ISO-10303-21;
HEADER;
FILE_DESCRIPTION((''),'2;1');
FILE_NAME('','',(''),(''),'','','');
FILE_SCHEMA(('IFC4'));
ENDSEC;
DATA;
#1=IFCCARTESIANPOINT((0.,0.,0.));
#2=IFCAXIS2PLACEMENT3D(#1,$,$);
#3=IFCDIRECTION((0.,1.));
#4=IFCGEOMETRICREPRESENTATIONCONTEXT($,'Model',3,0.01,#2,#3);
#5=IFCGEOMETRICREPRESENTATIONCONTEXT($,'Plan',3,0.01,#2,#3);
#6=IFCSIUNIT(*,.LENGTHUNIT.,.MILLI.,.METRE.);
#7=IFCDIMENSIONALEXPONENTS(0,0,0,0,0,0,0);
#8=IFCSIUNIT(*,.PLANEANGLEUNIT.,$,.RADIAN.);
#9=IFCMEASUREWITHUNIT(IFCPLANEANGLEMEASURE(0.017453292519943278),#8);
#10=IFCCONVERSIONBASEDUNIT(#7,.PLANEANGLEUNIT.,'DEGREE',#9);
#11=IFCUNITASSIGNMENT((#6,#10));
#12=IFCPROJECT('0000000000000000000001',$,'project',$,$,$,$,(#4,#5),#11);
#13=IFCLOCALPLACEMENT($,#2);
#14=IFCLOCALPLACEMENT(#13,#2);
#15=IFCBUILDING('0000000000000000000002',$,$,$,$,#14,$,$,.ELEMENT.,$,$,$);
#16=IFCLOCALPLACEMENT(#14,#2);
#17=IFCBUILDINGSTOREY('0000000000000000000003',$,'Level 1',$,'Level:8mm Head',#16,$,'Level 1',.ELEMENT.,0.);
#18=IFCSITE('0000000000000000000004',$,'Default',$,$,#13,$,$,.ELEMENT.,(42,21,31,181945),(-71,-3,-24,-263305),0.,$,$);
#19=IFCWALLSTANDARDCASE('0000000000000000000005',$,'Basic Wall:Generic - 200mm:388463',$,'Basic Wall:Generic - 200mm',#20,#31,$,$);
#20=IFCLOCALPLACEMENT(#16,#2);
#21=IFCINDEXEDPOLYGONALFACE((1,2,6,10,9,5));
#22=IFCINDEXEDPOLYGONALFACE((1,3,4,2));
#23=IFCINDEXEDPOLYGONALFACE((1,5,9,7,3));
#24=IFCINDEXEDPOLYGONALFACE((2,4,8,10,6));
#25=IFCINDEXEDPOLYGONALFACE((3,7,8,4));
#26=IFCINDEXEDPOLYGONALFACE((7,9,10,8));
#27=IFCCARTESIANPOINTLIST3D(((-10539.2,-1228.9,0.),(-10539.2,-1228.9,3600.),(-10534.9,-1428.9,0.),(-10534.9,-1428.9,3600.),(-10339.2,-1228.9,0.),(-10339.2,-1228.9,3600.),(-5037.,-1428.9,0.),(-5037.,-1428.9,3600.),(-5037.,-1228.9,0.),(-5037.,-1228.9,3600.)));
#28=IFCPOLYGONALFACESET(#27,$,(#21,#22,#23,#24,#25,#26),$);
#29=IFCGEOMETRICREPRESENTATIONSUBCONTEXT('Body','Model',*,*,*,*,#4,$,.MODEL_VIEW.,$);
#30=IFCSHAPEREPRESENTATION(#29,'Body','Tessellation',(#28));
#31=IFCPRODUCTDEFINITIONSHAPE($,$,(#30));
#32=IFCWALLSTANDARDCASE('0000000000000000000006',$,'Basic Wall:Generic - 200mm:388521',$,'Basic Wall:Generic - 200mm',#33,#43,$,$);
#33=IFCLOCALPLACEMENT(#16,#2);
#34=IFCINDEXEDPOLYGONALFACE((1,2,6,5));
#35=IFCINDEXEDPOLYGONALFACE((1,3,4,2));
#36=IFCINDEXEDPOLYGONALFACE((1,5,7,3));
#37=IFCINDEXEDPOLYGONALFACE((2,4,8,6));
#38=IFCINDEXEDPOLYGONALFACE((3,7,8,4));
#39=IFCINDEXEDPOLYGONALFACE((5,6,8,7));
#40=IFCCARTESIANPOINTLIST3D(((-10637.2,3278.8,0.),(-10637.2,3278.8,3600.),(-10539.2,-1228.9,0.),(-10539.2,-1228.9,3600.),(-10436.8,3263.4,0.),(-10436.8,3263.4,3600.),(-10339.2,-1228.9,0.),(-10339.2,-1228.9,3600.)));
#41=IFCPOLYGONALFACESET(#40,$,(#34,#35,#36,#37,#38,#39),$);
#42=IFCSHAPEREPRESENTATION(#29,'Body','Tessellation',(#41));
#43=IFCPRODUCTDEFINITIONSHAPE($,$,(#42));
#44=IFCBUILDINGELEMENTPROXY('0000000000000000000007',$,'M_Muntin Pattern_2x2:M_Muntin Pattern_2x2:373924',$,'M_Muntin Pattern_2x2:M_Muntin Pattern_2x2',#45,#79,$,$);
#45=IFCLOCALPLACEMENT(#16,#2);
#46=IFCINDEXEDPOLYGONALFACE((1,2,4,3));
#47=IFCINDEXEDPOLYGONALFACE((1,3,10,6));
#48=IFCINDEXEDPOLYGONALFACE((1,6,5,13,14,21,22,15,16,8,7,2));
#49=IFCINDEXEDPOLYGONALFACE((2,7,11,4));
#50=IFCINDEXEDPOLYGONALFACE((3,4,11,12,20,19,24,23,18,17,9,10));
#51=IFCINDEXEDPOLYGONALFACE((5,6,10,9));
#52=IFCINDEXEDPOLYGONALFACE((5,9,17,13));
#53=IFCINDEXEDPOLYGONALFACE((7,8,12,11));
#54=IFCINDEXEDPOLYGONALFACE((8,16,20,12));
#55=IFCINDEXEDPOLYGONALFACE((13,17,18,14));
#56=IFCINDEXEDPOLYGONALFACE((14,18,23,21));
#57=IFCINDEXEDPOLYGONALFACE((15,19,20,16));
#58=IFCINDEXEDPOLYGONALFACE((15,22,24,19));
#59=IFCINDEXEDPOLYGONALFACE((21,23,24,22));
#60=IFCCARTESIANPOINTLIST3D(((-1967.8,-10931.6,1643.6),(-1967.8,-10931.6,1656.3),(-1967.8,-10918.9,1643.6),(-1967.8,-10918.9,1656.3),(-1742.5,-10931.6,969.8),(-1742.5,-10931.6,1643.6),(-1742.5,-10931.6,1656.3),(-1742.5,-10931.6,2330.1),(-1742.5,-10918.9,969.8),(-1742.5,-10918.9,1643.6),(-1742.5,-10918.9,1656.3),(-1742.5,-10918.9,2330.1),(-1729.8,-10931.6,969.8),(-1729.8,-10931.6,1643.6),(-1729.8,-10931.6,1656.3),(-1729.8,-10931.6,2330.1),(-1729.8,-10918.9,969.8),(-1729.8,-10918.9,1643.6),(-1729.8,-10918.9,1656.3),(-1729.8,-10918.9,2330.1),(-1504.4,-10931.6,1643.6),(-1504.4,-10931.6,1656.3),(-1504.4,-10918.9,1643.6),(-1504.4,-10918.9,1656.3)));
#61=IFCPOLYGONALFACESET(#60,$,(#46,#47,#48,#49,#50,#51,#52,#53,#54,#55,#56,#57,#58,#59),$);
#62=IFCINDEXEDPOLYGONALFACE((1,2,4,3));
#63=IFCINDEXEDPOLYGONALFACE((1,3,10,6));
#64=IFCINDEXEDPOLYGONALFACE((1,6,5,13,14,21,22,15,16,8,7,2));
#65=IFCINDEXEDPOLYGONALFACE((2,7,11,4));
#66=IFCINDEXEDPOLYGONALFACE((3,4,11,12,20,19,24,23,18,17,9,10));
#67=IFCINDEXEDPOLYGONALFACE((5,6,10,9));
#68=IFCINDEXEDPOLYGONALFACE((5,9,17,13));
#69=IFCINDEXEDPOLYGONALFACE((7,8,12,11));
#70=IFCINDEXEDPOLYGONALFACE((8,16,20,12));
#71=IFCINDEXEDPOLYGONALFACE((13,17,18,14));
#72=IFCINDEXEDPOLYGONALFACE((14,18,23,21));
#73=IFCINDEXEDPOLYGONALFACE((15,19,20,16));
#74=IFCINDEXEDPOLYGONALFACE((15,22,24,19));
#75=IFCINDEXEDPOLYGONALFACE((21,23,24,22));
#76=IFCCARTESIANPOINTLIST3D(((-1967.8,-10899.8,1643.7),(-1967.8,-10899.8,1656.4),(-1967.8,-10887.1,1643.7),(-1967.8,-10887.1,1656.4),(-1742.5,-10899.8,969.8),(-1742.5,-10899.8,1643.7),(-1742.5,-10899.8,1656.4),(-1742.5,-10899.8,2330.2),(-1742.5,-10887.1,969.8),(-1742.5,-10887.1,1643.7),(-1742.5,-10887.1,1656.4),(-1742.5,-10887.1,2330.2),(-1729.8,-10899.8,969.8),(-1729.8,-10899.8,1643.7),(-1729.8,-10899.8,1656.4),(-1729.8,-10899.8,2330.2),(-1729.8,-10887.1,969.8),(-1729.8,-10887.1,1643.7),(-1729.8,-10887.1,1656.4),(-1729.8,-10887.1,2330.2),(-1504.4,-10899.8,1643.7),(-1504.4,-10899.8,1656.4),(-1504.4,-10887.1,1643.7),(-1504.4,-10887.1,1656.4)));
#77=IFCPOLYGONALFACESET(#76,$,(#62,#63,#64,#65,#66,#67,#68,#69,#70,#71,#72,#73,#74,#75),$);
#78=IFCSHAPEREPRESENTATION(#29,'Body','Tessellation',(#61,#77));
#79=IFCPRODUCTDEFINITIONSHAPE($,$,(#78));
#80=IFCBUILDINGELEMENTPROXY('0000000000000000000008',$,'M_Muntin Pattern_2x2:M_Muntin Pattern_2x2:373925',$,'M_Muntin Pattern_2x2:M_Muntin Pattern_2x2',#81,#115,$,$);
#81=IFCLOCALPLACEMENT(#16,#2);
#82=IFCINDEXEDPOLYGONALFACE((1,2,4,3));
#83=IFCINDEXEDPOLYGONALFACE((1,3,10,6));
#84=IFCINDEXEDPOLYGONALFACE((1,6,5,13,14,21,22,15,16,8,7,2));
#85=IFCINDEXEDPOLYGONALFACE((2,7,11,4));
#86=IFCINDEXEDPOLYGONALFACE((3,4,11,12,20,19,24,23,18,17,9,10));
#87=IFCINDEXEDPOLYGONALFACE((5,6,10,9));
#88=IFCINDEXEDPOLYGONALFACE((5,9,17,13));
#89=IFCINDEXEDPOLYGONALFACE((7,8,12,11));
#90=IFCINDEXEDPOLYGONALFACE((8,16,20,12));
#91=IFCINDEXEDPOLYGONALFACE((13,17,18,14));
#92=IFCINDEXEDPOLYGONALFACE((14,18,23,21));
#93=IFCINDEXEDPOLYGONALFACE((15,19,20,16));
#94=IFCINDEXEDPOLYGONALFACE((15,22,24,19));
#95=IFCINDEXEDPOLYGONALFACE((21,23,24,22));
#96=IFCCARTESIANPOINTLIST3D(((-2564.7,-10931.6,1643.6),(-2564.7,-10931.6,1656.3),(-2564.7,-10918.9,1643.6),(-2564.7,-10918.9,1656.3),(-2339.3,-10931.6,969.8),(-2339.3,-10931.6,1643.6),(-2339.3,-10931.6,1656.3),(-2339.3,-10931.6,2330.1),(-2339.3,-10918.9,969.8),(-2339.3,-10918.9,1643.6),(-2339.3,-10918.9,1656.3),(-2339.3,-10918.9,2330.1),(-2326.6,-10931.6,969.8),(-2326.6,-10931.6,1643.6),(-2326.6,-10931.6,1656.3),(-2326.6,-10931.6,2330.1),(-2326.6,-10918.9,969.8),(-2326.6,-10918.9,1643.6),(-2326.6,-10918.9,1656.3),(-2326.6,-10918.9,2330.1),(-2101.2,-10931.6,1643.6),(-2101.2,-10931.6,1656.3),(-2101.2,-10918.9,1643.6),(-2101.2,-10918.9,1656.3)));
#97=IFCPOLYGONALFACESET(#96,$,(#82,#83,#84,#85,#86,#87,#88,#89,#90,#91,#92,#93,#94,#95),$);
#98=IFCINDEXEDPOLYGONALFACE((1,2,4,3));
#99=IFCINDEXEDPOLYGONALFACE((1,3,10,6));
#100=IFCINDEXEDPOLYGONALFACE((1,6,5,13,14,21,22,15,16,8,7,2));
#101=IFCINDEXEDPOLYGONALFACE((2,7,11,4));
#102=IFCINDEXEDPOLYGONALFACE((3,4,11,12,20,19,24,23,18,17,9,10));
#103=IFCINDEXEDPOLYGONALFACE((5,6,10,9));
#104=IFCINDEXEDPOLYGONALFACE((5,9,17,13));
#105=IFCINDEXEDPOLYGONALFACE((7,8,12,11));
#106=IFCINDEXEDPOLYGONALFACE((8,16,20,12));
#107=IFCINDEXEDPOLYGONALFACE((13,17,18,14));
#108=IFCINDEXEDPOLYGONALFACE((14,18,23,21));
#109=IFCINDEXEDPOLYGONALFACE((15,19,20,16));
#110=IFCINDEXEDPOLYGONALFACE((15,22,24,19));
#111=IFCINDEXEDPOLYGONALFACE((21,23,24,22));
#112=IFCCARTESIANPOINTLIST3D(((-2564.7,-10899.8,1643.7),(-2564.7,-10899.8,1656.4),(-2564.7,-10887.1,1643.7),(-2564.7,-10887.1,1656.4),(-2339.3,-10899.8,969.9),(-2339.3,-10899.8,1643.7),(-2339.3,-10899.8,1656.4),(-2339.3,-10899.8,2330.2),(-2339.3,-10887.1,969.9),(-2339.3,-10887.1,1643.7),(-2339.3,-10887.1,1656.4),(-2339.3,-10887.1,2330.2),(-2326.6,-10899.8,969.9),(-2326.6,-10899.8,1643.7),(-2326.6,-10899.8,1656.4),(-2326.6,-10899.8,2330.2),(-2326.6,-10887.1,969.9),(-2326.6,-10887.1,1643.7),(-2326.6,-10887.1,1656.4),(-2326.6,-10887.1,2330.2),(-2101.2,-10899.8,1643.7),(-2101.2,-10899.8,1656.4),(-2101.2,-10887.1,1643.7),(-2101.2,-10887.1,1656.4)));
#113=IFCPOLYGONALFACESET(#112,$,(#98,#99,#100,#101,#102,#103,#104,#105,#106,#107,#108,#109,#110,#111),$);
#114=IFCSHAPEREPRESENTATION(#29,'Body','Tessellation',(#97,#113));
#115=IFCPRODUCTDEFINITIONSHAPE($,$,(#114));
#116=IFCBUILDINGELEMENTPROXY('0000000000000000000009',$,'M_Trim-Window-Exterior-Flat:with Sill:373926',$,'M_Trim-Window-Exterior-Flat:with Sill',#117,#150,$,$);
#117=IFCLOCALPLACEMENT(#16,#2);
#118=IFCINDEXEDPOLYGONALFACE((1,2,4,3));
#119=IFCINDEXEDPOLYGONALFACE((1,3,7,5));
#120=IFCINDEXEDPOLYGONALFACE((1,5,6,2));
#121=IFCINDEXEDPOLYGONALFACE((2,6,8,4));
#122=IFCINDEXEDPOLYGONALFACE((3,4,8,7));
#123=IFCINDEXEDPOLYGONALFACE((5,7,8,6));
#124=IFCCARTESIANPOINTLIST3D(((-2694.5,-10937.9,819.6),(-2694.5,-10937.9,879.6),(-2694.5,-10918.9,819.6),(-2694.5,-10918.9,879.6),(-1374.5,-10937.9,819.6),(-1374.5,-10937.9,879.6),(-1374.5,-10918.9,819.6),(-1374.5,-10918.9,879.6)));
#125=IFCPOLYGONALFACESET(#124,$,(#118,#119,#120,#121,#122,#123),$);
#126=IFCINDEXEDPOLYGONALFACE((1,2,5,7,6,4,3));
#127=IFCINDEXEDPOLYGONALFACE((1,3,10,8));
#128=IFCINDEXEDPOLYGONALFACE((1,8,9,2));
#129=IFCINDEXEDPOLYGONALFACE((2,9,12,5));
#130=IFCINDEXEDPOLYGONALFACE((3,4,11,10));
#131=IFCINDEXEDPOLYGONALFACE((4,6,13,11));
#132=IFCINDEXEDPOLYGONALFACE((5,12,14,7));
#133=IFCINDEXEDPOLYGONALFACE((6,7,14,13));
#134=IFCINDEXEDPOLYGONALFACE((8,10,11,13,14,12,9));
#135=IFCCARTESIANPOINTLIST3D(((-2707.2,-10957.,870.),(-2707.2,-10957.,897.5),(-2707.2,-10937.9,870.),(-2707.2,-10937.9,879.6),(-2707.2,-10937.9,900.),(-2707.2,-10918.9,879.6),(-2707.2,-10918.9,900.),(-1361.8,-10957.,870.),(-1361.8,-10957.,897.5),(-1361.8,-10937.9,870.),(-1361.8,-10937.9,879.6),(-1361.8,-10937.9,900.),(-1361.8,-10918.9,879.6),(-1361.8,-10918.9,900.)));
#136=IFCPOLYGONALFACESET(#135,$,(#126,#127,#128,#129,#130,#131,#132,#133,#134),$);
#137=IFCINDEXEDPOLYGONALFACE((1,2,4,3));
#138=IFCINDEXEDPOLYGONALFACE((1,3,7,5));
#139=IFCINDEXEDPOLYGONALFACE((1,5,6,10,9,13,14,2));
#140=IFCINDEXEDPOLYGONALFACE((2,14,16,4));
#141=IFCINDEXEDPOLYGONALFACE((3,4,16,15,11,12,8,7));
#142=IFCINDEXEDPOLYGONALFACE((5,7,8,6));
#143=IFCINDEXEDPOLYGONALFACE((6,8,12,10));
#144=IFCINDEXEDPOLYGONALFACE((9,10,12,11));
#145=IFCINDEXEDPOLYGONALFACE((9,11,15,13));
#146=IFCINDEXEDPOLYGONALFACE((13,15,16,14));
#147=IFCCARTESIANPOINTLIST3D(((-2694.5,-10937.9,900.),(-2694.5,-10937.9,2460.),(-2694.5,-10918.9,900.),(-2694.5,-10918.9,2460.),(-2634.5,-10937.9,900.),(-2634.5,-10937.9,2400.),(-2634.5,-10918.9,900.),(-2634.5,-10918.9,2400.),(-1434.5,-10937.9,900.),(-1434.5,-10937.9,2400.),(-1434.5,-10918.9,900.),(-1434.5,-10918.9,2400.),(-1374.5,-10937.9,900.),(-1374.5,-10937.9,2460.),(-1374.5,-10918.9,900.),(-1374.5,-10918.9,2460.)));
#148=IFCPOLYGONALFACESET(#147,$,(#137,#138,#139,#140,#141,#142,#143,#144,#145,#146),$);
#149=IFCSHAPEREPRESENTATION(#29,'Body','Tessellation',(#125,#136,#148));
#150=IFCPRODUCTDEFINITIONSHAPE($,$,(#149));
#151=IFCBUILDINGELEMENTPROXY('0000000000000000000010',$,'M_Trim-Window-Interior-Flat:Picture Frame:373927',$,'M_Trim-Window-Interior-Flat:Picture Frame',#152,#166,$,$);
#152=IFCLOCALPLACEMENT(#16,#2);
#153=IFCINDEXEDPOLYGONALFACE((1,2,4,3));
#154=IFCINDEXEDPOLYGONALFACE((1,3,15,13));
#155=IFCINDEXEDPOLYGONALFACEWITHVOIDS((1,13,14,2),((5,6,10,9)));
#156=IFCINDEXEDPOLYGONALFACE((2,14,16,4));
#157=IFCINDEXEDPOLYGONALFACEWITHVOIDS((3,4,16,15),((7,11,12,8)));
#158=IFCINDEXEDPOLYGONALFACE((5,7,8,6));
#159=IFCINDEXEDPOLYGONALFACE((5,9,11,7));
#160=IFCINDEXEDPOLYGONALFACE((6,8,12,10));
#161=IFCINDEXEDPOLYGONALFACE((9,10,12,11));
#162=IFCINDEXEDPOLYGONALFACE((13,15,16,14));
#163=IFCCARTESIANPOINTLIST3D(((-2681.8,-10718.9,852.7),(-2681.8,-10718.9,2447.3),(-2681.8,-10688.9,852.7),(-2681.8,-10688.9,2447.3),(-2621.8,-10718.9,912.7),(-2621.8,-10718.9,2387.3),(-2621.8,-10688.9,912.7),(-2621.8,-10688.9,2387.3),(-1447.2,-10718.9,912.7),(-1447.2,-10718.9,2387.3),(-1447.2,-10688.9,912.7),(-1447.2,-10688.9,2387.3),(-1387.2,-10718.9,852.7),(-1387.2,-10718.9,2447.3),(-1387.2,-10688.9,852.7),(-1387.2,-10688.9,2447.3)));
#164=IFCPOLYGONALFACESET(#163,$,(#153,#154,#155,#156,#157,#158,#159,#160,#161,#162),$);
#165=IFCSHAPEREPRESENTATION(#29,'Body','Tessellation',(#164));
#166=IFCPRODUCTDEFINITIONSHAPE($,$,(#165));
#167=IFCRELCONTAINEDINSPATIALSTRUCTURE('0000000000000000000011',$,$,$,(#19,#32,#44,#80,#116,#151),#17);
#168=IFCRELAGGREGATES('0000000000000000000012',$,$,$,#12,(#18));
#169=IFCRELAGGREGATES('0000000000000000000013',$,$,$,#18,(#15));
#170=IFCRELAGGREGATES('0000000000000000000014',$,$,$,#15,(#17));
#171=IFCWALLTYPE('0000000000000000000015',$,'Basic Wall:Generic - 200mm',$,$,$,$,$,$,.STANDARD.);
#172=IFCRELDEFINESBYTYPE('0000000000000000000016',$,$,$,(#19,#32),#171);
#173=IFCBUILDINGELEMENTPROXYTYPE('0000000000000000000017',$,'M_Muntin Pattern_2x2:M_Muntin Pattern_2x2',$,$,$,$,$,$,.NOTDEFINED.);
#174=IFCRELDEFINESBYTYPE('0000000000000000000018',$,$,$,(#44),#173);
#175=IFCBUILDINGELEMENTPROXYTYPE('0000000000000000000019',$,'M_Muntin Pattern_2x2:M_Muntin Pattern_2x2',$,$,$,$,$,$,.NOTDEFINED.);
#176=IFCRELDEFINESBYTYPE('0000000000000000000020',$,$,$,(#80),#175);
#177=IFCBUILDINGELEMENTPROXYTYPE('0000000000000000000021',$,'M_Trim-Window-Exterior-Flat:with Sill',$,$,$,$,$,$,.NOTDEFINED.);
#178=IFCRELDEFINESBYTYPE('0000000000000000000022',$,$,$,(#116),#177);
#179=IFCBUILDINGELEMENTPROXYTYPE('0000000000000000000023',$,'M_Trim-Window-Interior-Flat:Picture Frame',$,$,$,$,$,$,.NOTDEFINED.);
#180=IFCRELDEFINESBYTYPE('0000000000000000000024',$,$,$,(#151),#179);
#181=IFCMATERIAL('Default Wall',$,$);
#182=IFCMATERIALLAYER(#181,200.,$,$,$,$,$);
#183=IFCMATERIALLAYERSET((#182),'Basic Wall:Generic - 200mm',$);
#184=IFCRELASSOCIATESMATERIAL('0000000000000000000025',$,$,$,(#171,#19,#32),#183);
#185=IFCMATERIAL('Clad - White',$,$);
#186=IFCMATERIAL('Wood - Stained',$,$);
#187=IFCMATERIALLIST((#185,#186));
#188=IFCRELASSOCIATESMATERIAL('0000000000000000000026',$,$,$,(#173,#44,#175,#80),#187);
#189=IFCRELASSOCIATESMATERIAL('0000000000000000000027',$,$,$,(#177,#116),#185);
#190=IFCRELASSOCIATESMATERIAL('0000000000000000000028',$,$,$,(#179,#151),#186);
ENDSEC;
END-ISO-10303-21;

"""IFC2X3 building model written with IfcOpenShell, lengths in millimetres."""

from ifc_helpers import new_model, entity, si_unit, converted_unit, direction, frame, frame_2d, origin, place, context, subcontext, project, spatial, polyline, rectangle, outline, extrude, source, transform, mapped, material, material_list, layer, layer_set, layer_usage, type_object, type_shapes, element, save


model = new_model("IFC2X3")

# Units and contexts
model_context = context("Model", 3, precision=0.01, world=origin(), true_north=direction((0.0, 1.0)))
plan_context = context("Plan", 3, precision=0.01, world=origin(), true_north=direction((0.0, 1.0)))
body_context = subcontext(model_context, "Body", "Model", "MODEL_VIEW")
ifc_project = project(units=[si_unit("LENGTHUNIT", "METRE", prefix="MILLI"), converted_unit("PLANEANGLEUNIT", "DEGREE", entity("IfcPlaneAngleMeasure", 0.017453292519943278), si_unit("PLANEANGLEUNIT", "RADIAN"), dimensions=[0, 0, 0, 0, 0, 0, 0])], contexts=[model_context, plan_context])

# Site, building, storey
site_placement = place(None, origin())
site = spatial("IfcSite", under=ifc_project, at=site_placement, Name="Default", CompositionType="ELEMENT", RefLatitude=(42, 21, 31, 181945), RefLongitude=(-71, -3, -24, -263305), RefElevation=0.0)
building_placement = place(site_placement, origin())
building = spatial("IfcBuilding", under=site, at=building_placement, CompositionType="ELEMENT")
storey_placement = place(building_placement, origin())
storey = spatial("IfcBuildingStorey", under=building, at=storey_placement, Name="Level 1", ObjectType="Level:8mm Head", LongName="Level 1", CompositionType="ELEMENT", Elevation=0.0)

# Shared definitions
ifc_material_1 = material(Name="Default Wall")
ifc_layer_1 = layer(ifc_material_1, 200.0)
ifc_layer_set_1 = layer_set([ifc_layer_1], Name="Basic Wall:Generic - 200mm")
wall_type = type_object("IfcWallType", Name="Basic Wall:Generic - 200mm", PredefinedType="STANDARD", material=ifc_layer_set_1)

# Walls
ifc_layer_usage_1 = layer_usage(ifc_layer_set_1, "AXIS2", "NEGATIVE", 100.0)
wall_1_placement = place(storey_placement, frame((-5037.0, -1328.9, 0.0), z_axis=(0.0, 0.0, 1.0), x_axis=(-1.0, 0.0, 0.0)))
element("IfcWallStandardCase", 1, at=wall_1_placement, inside=storey, type_object=wall_type, material=ifc_layer_usage_1, Name="Basic Wall:Generic - 200mm:388463", ObjectType="Basic Wall:Generic - 200mm", context=body_context, shape_type="SweptSolid", body=[
    extrude(outline(polyline([(5502.2, -100.0), (5497.8, 100.0), (0.0, 100.0), (0.0, -100.0), (5302.2, -100.0), (5502.2, -100.0)])), origin(), (0.0, 0.0, 1.0), 3600.0),
])
ifc_layer_usage_2 = layer_usage(ifc_layer_set_1, "AXIS2", "NEGATIVE", 100.0)
wall_2_placement = place(storey_placement, frame((-10439.1, -1231.1, 0.0), z_axis=(0.0, 0.0, 1.0), x_axis=(-0.021734, 0.999764, 0.0)))
element("IfcWallStandardCase", 2, at=wall_2_placement, inside=storey, type_object=wall_type, material=ifc_layer_usage_2, Name="Basic Wall:Generic - 200mm:388521", ObjectType="Basic Wall:Generic - 200mm", context=body_context, shape_type="SweptSolid", body=[
    extrude(outline(polyline([(4493.4, -100.0), (4513.1, 100.0), (4.3, 100.0), (0.0, -100.0), (4493.4, -100.0)])), origin(), (0.0, 0.0, 1.0), 3600.0),
])

# Building element proxies
ifc_material_2 = material(Name="Clad - White")
ifc_material_3 = material(Name="Wood - Stained")
ifc_material_list = material_list([ifc_material_2, ifc_material_3])
building_element_proxy_type_1 = type_object("IfcBuildingElementProxyType", Name="M_Muntin Pattern_2x2:M_Muntin Pattern_2x2", PredefinedType="NOTDEFINED", material=ifc_material_list)
shared_shape_1 = source(origin(), body_context, "Body", "SweptSolid", [
    extrude(outline(polyline([(6.4, -6.4), (680.1, -6.4), (680.1, 6.3), (6.4, 6.3), (6.4, 231.7), (-6.3, 231.7), (-6.3, 6.3), (-680.2, 6.3), (-680.2, -6.4), (-6.3, -6.4), (-6.3, -231.7), (6.4, -231.7), (6.4, -6.4)])), frame((0.0, 9.5, 680.1), z_axis=(0.0, 1.0, 0.0), x_axis=(0.0, 0.0, 1.0)), (0.0, 0.0, 1.0), 12.7),
    extrude(outline(polyline([(6.4, -6.4), (680.2, -6.4), (680.2, 6.3), (6.4, 6.3), (6.4, 231.7), (-6.3, 231.7), (-6.3, 6.3), (-680.2, 6.3), (-680.2, -6.4), (-6.3, -6.4), (-6.3, -231.7), (6.4, -231.7), (6.4, -6.4)])), frame((0.0, -22.2, 680.2), z_axis=(0.0, 1.0, 0.0), x_axis=(0.0, 0.0, 1.0)), (0.0, 0.0, 1.0), 12.7),
])
type_shapes(building_element_proxy_type_1, [shared_shape_1])
proxy_1_placement = place(storey_placement, frame((-1736.1, -10909.4, 969.8), z_axis=(0.0, 0.0, 1.0), x_axis=(-1.0, 0.0, 0.0)))
element("IfcBuildingElementProxy", 3, at=proxy_1_placement, inside=storey, type_object=building_element_proxy_type_1, material=ifc_material_list, Name="M_Muntin Pattern_2x2:M_Muntin Pattern_2x2:373924", ObjectType="M_Muntin Pattern_2x2:M_Muntin Pattern_2x2", context=body_context, shape_type="MappedRepresentation", body=[
    mapped(shared_shape_1, transform((0.0, 0.0, 0.0), scale=1.0)),
])
building_element_proxy_type_2 = type_object("IfcBuildingElementProxyType", Name="M_Muntin Pattern_2x2:M_Muntin Pattern_2x2", PredefinedType="NOTDEFINED", material=ifc_material_list)
shared_shape_2 = source(origin(), body_context, "Body", "SweptSolid", [
    extrude(outline(polyline([(6.4, -6.4), (680.1, -6.4), (680.1, 6.3), (6.4, 6.3), (6.4, 231.7), (-6.3, 231.7), (-6.3, 6.3), (-680.2, 6.3), (-680.2, -6.4), (-6.3, -6.4), (-6.3, -231.7), (6.4, -231.7), (6.4, -6.4)])), frame((0.0, -22.2, 680.1), z_axis=(0.0, 1.0, 0.0), x_axis=(0.0, 0.0, 1.0)), (0.0, 0.0, 1.0), 12.7),
    extrude(outline(polyline([(6.4, -6.4), (680.2, -6.4), (680.2, 6.3), (6.4, 6.3), (6.4, 231.7), (-6.3, 231.7), (-6.3, 6.3), (-680.2, 6.3), (-680.2, -6.4), (-6.3, -6.4), (-6.3, -231.7), (6.4, -231.7), (6.4, -6.4)])), frame((0.0, 9.5, 680.2), z_axis=(0.0, 1.0, 0.0), x_axis=(0.0, 0.0, 1.0)), (0.0, 0.0, 1.0), 12.7),
])
type_shapes(building_element_proxy_type_2, [shared_shape_2])
proxy_2_placement = place(storey_placement, frame((-2332.9, -10909.4, 969.9)))
element("IfcBuildingElementProxy", 4, at=proxy_2_placement, inside=storey, type_object=building_element_proxy_type_2, material=ifc_material_list, Name="M_Muntin Pattern_2x2:M_Muntin Pattern_2x2:373925", ObjectType="M_Muntin Pattern_2x2:M_Muntin Pattern_2x2", context=body_context, shape_type="MappedRepresentation", body=[
    mapped(shared_shape_2, transform((0.0, 0.0, 0.0), scale=1.0)),
])
building_element_proxy_type_3 = type_object("IfcBuildingElementProxyType", Name="M_Trim-Window-Exterior-Flat:with Sill", PredefinedType="NOTDEFINED", material=ifc_material_2)
shared_shape_3 = source(origin(), body_context, "Body", "SweptSolid", [
    extrude(rectangle(XDim=1320.0, YDim=60.0, at=frame_2d((0.0, 0.0), x_axis=(1.0, 0.0))), frame((0.0, -1550.4, 0.0), z_axis=(0.0, 0.0, 1.0), x_axis=(-1.0, 0.0, 0.0)), (0.0, 0.0, 1.0), 19.0),
    extrude(outline(polyline([(-19.0, -15.2), (0.0, -15.2), (0.0, -5.7), (19.0, -5.7), (19.0, 14.8), (0.0, 14.8), (-19.0, 12.3), (-19.0, -15.2)])), frame((-672.7, -1514.8, 19.0), z_axis=(1.0, 0.0, 0.0), x_axis=(0.0, 0.0, -1.0)), (0.0, 0.0, 1.0), 1345.4),
    extrude(outline(polyline([(-795.0, -660.0), (765.0, -660.0), (765.0, -600.0), (-735.0, -600.0), (-735.0, 600.0), (765.0, 600.0), (765.0, 660.0), (-795.0, 660.0), (-795.0, -660.0)])), frame((0.0, -735.0, 0.0), z_axis=(0.0, 0.0, 1.0), x_axis=(0.0, -1.0, 0.0)), (0.0, 0.0, 1.0), 19.0),
])
type_shapes(building_element_proxy_type_3, [shared_shape_3])
proxy_3_placement = place(storey_placement, frame((-2034.5, -10918.9, 2400.0), z_axis=(0.0, -1.0, 0.0), x_axis=(1.0, 0.0, 0.0)))
element("IfcBuildingElementProxy", 5, at=proxy_3_placement, inside=storey, type_object=building_element_proxy_type_3, material=ifc_material_2, Name="M_Trim-Window-Exterior-Flat:with Sill:373926", ObjectType="M_Trim-Window-Exterior-Flat:with Sill", context=body_context, shape_type="MappedRepresentation", body=[
    mapped(shared_shape_3, transform((0.0, 0.0, 0.0), scale=1.0)),
])
building_element_proxy_type_4 = type_object("IfcBuildingElementProxyType", Name="M_Trim-Window-Interior-Flat:Picture Frame", PredefinedType="NOTDEFINED", material=ifc_material_3)
shared_shape_4 = source(origin(), body_context, "Body", "SweptSolid", [
    extrude(outline(polyline([(-647.3, -797.3), (647.3, -797.3), (647.3, 797.3), (-647.3, 797.3), (-647.3, -797.3)]), holes=[polyline([(-587.3, -737.3), (-587.3, 737.3), (587.3, 737.3), (587.3, -737.3), (-587.3, -737.3)])]), frame((0.0, -750.0, 0.0), z_axis=(0.0, 0.0, 1.0), x_axis=(-1.0, 0.0, 0.0)), (0.0, 0.0, 1.0), 30.0),
])
type_shapes(building_element_proxy_type_4, [shared_shape_4])
proxy_4_placement = place(storey_placement, frame((-2034.5, -10718.9, 2400.0), z_axis=(0.0, 1.0, 0.0), x_axis=(-1.0, 0.0, 0.0)))
element("IfcBuildingElementProxy", 6, at=proxy_4_placement, inside=storey, type_object=building_element_proxy_type_4, material=ifc_material_3, Name="M_Trim-Window-Interior-Flat:Picture Frame:373927", ObjectType="M_Trim-Window-Interior-Flat:Picture Frame", context=body_context, shape_type="MappedRepresentation", body=[
    mapped(shared_shape_4, transform((0.0, 0.0, 0.0), scale=1.0)),
])

save(model, "model.ifc")
